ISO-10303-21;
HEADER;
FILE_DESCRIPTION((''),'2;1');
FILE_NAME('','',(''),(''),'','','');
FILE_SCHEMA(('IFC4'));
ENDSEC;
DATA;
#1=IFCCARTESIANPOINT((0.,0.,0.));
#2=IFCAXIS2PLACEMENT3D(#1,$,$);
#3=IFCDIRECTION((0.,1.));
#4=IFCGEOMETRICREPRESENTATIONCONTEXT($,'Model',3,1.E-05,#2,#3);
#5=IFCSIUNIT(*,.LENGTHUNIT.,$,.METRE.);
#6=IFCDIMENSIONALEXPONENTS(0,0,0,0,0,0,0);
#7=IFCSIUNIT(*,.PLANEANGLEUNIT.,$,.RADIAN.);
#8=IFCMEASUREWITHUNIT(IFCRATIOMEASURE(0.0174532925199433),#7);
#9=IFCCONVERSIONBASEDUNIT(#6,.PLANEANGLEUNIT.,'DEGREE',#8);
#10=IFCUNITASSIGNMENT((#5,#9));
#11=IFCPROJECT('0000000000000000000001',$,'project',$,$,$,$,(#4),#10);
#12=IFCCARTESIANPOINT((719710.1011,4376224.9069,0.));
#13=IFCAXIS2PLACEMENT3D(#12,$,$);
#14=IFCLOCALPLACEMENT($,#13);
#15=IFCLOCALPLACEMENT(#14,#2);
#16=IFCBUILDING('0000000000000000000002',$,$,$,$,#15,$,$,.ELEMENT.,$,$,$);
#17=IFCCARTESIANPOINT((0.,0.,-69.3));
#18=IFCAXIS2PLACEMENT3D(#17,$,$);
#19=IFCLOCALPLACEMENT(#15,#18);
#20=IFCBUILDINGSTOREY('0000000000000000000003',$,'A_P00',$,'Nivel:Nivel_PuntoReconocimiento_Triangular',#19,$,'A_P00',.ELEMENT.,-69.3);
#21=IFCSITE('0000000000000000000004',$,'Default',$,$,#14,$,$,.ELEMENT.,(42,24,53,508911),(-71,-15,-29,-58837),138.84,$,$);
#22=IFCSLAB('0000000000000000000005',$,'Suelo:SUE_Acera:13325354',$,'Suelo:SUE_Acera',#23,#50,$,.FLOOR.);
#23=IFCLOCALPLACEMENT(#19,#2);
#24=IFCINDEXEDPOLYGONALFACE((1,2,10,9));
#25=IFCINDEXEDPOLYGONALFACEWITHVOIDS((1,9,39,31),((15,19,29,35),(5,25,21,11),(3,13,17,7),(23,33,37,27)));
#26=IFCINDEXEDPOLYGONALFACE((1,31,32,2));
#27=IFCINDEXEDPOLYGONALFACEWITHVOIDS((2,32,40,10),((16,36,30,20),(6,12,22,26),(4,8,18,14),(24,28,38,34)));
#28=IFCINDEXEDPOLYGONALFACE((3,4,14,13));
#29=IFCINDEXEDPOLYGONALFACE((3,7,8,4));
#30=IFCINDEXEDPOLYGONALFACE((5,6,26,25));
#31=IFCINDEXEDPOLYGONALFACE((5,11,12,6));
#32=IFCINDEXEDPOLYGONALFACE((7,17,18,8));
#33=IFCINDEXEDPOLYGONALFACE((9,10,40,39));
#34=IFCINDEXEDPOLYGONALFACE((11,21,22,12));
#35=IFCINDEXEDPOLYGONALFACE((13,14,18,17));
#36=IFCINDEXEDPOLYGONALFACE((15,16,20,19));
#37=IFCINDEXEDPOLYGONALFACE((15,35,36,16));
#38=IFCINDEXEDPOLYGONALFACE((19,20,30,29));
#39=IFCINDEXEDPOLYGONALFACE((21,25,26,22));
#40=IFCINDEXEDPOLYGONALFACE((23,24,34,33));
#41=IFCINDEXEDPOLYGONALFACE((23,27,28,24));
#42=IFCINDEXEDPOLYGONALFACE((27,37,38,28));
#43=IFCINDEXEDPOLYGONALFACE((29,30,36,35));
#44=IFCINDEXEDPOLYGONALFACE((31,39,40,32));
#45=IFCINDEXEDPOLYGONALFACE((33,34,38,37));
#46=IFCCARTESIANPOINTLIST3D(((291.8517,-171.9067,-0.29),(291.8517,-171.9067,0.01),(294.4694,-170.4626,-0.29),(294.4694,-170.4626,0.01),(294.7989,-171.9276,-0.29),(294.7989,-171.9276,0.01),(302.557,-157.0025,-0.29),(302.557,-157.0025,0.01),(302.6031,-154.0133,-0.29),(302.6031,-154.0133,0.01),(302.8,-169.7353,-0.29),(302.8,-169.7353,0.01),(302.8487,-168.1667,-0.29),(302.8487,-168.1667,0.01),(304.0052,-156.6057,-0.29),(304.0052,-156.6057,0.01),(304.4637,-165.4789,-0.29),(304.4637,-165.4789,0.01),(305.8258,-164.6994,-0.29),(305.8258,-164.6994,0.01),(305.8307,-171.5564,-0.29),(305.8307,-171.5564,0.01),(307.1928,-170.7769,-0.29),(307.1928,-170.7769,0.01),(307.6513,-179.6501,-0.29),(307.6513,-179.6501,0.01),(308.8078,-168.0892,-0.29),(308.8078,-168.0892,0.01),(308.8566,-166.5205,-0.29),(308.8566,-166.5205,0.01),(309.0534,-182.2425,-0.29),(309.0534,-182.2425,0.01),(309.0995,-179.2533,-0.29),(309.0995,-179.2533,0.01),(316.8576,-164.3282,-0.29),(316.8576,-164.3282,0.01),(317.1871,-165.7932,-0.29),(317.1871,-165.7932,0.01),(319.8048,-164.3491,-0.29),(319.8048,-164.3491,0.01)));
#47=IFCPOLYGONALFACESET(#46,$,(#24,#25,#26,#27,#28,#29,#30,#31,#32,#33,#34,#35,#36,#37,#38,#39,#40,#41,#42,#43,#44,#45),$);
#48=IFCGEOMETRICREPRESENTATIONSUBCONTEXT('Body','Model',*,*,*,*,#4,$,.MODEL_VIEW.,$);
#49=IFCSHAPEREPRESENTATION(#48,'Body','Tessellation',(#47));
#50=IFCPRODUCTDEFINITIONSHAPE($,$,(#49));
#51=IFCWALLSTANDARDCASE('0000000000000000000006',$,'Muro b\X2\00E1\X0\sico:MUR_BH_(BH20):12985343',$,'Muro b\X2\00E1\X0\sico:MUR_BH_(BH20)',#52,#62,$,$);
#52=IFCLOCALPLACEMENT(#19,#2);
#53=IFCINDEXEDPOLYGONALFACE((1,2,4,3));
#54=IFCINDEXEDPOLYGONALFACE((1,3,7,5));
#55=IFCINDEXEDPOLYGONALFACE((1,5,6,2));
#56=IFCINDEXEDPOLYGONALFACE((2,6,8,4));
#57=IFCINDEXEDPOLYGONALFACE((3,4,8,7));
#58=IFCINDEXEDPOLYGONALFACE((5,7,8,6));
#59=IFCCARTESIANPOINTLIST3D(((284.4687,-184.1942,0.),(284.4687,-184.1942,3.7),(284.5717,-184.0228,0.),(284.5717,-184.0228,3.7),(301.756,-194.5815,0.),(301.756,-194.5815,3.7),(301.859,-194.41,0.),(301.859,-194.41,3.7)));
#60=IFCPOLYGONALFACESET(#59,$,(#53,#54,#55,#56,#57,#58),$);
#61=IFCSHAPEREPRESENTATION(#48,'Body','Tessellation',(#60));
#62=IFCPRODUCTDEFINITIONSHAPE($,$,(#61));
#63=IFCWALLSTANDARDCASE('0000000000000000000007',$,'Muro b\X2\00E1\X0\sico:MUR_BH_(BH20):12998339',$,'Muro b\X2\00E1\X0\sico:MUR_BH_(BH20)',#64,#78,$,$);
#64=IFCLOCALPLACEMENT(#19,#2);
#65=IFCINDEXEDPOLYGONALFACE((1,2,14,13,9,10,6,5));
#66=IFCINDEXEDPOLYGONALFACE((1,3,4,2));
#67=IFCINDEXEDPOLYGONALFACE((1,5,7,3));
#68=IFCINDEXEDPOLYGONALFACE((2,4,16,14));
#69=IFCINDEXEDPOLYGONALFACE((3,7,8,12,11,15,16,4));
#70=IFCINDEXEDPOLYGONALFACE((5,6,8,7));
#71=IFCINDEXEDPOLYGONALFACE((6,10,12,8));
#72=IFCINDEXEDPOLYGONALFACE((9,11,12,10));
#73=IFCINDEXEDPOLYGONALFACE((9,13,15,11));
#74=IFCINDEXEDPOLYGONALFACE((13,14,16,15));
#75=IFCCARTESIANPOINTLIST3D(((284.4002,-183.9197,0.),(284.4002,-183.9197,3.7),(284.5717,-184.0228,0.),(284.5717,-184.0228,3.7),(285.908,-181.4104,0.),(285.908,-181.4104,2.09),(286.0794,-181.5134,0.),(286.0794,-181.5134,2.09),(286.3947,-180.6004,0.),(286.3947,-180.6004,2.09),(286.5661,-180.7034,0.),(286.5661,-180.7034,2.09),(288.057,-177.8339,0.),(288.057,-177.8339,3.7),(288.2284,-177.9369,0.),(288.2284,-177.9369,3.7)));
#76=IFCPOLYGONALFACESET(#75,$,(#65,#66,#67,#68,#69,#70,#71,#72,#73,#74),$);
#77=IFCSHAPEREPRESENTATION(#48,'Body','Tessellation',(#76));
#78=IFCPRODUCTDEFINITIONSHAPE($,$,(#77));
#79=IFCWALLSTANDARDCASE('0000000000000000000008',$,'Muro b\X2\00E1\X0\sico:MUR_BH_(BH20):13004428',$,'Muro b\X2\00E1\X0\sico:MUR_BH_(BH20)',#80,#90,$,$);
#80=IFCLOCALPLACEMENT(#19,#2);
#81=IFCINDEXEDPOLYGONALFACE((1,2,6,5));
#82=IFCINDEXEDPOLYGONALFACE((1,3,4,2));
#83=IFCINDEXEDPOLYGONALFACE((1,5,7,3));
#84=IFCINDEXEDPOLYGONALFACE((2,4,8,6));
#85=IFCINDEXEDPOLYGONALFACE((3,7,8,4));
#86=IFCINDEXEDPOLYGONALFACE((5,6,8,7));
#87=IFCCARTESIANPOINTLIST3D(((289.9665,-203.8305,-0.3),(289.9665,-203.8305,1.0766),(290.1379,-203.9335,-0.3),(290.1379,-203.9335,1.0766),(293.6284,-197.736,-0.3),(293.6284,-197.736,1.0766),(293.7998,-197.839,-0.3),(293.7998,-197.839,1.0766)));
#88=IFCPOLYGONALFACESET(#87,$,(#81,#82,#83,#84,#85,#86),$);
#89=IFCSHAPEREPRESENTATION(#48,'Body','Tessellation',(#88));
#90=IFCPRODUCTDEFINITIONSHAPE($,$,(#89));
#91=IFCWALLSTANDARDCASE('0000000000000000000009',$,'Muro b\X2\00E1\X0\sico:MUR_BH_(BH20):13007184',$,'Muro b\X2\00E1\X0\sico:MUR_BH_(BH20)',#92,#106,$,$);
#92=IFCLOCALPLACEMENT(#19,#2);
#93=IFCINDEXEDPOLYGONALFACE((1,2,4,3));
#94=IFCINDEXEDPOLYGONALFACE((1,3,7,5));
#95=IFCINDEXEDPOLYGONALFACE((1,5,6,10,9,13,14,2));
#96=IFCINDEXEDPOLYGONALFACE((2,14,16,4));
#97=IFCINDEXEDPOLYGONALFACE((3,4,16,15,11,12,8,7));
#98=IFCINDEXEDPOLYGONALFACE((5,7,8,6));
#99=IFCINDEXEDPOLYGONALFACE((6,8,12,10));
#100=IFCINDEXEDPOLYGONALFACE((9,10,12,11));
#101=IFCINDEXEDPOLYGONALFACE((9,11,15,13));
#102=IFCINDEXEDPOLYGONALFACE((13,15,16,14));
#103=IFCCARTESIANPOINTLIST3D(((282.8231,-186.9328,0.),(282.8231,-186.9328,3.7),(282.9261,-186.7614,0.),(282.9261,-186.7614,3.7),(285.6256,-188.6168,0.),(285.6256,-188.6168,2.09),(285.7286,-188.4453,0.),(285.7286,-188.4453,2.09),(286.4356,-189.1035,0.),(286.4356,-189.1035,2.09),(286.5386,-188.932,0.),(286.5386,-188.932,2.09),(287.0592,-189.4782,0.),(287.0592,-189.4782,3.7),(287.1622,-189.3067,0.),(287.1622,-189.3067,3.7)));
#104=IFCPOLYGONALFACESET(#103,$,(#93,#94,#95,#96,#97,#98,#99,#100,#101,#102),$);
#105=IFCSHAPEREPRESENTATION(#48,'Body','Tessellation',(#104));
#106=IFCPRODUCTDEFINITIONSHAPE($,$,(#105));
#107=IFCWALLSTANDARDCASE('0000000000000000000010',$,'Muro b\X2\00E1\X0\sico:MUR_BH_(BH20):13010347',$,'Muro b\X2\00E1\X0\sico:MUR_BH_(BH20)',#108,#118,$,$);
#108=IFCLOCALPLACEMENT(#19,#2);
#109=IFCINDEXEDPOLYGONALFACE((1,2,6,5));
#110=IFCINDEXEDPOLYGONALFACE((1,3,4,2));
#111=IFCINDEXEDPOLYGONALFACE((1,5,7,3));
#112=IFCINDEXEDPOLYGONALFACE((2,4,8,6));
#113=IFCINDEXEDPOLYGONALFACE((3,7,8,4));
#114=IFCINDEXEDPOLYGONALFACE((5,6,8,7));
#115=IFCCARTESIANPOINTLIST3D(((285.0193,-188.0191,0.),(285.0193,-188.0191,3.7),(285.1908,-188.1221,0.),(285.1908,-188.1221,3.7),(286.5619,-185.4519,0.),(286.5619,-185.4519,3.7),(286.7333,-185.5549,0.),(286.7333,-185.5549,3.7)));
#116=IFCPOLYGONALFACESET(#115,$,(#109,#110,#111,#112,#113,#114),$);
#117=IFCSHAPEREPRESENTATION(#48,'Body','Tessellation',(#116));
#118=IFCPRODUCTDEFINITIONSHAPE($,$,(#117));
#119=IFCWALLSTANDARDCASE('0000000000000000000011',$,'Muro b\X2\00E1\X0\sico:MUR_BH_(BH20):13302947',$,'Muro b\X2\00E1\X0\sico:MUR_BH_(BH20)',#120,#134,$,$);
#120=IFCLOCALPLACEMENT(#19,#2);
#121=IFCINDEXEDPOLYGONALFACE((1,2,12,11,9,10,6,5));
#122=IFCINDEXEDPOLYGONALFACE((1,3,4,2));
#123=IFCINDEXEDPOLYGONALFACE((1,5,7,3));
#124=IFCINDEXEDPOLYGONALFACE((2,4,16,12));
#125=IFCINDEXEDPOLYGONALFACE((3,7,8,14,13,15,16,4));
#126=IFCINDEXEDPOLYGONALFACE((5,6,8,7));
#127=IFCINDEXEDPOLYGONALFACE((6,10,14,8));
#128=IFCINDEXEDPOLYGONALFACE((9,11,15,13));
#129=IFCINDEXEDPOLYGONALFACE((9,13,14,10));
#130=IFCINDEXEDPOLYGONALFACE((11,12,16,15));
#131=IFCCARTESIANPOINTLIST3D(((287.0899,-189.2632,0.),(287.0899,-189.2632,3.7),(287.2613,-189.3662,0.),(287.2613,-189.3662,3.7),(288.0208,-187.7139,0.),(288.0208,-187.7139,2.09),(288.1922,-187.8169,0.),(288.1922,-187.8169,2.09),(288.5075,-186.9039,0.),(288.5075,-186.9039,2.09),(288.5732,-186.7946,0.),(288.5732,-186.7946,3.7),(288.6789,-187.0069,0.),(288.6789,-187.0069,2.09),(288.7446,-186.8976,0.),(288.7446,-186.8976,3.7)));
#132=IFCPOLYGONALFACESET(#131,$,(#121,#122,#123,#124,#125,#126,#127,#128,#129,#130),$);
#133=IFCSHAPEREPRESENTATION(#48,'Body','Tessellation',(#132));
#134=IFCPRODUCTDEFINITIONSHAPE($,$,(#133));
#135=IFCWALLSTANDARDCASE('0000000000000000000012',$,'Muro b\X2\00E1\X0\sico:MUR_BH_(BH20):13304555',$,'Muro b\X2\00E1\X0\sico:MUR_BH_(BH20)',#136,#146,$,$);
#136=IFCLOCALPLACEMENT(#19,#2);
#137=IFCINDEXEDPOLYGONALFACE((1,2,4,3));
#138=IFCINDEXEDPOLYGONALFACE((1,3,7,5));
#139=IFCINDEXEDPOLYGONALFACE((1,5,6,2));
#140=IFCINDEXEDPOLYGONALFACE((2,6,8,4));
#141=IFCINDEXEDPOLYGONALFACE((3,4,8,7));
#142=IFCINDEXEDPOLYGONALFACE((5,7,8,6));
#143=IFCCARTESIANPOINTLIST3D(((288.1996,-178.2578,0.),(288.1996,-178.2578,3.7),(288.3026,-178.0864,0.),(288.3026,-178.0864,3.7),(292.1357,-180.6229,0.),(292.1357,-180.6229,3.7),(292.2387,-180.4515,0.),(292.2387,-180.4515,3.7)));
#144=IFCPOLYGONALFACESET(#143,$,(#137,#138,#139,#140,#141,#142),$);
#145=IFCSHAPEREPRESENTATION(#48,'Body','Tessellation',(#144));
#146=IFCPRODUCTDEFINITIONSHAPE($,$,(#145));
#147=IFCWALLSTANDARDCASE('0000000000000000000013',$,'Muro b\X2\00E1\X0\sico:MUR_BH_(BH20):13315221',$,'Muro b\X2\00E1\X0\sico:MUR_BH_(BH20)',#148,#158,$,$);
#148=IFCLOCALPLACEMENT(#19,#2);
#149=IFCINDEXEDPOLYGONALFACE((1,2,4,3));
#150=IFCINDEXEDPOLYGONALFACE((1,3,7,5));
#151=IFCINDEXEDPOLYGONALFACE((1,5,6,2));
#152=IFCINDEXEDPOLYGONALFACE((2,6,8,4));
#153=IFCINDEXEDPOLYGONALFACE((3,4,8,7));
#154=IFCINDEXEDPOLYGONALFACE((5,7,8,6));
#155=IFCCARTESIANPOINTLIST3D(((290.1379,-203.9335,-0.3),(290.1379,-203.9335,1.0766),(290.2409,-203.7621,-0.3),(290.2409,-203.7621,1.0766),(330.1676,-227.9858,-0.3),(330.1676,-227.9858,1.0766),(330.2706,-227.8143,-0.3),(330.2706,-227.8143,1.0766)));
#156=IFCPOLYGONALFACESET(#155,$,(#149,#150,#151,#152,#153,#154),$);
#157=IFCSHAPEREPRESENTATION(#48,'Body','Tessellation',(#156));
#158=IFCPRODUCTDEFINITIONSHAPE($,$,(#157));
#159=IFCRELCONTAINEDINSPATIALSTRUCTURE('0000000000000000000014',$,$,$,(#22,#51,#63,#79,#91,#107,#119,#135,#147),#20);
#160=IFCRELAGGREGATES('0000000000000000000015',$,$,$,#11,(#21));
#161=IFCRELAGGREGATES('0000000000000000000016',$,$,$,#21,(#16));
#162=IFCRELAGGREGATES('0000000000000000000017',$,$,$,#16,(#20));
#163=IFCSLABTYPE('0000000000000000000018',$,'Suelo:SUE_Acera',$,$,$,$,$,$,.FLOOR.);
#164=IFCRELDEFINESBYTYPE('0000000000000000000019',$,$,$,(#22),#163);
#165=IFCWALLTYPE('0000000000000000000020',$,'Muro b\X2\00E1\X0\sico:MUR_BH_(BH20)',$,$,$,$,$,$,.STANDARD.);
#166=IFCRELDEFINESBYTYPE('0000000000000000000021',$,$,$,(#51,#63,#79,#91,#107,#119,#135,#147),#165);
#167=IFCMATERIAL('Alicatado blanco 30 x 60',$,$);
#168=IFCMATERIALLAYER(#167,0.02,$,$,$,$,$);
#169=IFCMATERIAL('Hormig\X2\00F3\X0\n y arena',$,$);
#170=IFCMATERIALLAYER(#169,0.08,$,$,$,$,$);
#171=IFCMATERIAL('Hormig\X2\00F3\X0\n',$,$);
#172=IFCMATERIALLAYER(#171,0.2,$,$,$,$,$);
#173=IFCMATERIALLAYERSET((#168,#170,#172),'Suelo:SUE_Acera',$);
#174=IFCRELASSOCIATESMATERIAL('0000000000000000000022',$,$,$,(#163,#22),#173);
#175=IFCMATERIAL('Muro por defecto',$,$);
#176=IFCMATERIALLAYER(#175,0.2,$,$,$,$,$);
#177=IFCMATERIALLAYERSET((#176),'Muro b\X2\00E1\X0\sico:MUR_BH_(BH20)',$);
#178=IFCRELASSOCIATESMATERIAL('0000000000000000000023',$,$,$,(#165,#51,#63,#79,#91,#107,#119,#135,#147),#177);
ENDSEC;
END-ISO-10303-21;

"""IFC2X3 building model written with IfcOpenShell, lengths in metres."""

from ifc_helpers import new_model, entity, si_unit, converted_unit, direction, frame, frame_2d, origin, place, context, subcontext, project, spatial, polyline, rectangle, outline, extrude, material, layer, layer_set, layer_usage, type_object, element, save


model = new_model("IFC2X3")

# Units and contexts
model_context = context("Model", 3, precision=1e-05, world=origin(), true_north=direction((0.0, 1.0)))
body_context = subcontext(model_context, "Body", "Model", "MODEL_VIEW")
ifc_project = project(units=[si_unit("LENGTHUNIT", "METRE"), converted_unit("PLANEANGLEUNIT", "DEGREE", entity("IfcRatioMeasure", 0.0174532925199433), si_unit("PLANEANGLEUNIT", "RADIAN"), dimensions=[0, 0, 0, 0, 0, 0, 0])], contexts=[model_context])

# Site, building, storey
site_placement = place(None, frame((719710.1011, 4376224.9069, 0.0)))
site = spatial("IfcSite", under=ifc_project, at=site_placement, Name="Default", CompositionType="ELEMENT", RefLatitude=(42, 24, 53, 508911), RefLongitude=(-71, -15, -29, -58837), RefElevation=138.84)
building_placement = place(site_placement, origin())
building = spatial("IfcBuilding", under=site, at=building_placement, CompositionType="ELEMENT")
storey_placement = place(building_placement, frame((0.0, 0.0, -69.3)))
storey = spatial("IfcBuildingStorey", under=building, at=storey_placement, Name="A_P00", ObjectType="Nivel:Nivel_PuntoReconocimiento_Triangular", LongName="A_P00", CompositionType="ELEMENT", Elevation=-69.3)

# Slab, openings
ifc_material_1 = material(Name="Alicatado blanco 30 x 60")
ifc_layer_1 = layer(ifc_material_1, 0.02)
ifc_material_2 = material(Name="Hormigón y arena")
ifc_layer_2 = layer(ifc_material_2, 0.08)
ifc_material_3 = material(Name="Hormigón")
ifc_layer_3 = layer(ifc_material_3, 0.2)
ifc_layer_set_1 = layer_set([ifc_layer_1, ifc_layer_2, ifc_layer_3], Name="Suelo:SUE_Acera")
ifc_layer_usage_1 = layer_usage(ifc_layer_set_1, "AXIS3", "POSITIVE", 0.0)
slab_type = type_object("IfcSlabType", Name="Suelo:SUE_Acera", PredefinedType="FLOOR", material=ifc_layer_set_1)
slab_placement = place(storey_placement, frame((291.8517, -182.2425, -0.29)))
slab = element("IfcSlab", 1, at=slab_placement, inside=storey, type_object=slab_type, material=ifc_layer_usage_1, Name="Suelo:SUE_Acera:13325354", ObjectType="Suelo:SUE_Acera", PredefinedType="FLOOR", context=body_context, shape_type="SweptSolid", body=[
    extrude(rectangle(XDim=20.068, YDim=20.875, at=frame_2d((0.0, 0.0), x_axis=(-0.857167, -0.515038))), frame((13.9765, 14.1146, 0.3), z_axis=(0.0, 0.0, -1.0), x_axis=(-1.0, 0.0, 0.0)), (0.0, 0.0, 1.0), 0.3),
])
opening_1_placement = place(slab_placement, frame((10.9185, 9.0251, 0.3)))
element("IfcOpeningElement", 2, at=opening_1_placement, cuts=slab, ObjectType="Opening", context=body_context, shape_type="SweptSolid", body=[
    extrude(outline(polyline([(-7.497, 3.0), (-1.7679, -3.0), (1.7679, -3.0), (7.497, 3.0), (-7.497, 3.0)])), frame((0.0, 0.0, 0.0), z_axis=(0.0, 0.0, 1.0), x_axis=(-0.857167, 0.515038, 0.0)), (0.0, 0.0, -1.0), 0.3),
])
opening_2_placement = place(slab_placement, frame((9.233, 16.9648, 0.3)))
element("IfcOpeningElement", 3, at=opening_2_placement, cuts=slab, ObjectType="Opening", context=body_context, shape_type="SweptSolid", body=[
    extrude(outline(polyline([(-7.8515, 3.0), (-1.5678, -3.0), (1.5678, -3.0), (7.8515, 3.0), (-7.8515, 3.0)])), frame((0.0, 0.0, 0.0), z_axis=(0.0, 0.0, 1.0), x_axis=(0.515038, 0.857167, 0.0)), (0.0, 0.0, -1.0), 0.3),
])
opening_3_placement = place(slab_placement, frame((17.0346, 19.204, 0.3)))
element("IfcOpeningElement", 4, at=opening_3_placement, cuts=slab, ObjectType="Opening", context=body_context, shape_type="SweptSolid", body=[
    extrude(outline(polyline([(-7.497, -3.0), (7.497, -3.0), (1.7679, 3.0), (-1.7679, 3.0), (-7.497, -3.0)])), frame((0.0, 0.0, 0.0), z_axis=(0.0, 0.0, -1.0), x_axis=(0.857167, -0.515038, 0.0)), (0.0, 0.0, 1.0), 0.3),
])
opening_4_placement = place(slab_placement, frame((18.7201, 11.2644, 0.3)))
element("IfcOpeningElement", 5, at=opening_4_placement, cuts=slab, ObjectType="Opening", context=body_context, shape_type="SweptSolid", body=[
    extrude(outline(polyline([(-7.8515, -3.0), (7.8515, -3.0), (1.5678, 3.0), (-1.5678, 3.0), (-7.8515, -3.0)])), frame((0.0, 0.0, 0.0), z_axis=(0.0, 0.0, -1.0), x_axis=(-0.515038, -0.857167, 0.0)), (0.0, 0.0, 1.0), 0.3),
])

# Wall
ifc_material_4 = material(Name="Muro por defecto")
ifc_layer_4 = layer(ifc_material_4, 0.2)
ifc_layer_set_2 = layer_set([ifc_layer_4], Name="Muro básico:MUR_BH_(BH20)")
ifc_layer_usage_2 = layer_usage(ifc_layer_set_2, "AXIS2", "NEGATIVE", 0.1)
wall_type = type_object("IfcWallType", Name="Muro básico:MUR_BH_(BH20)", PredefinedType="STANDARD", material=ifc_layer_set_2)
wall_1_placement = place(storey_placement, frame((284.5202, -184.1085, 0.0), z_axis=(0.0, 0.0, 1.0), x_axis=(0.857167, -0.515038, 0.0)))
element("IfcWallStandardCase", 6, at=wall_1_placement, inside=storey, type_object=wall_type, material=ifc_layer_usage_2, Name="Muro básico:MUR_BH_(BH20):12985343", ObjectType="Muro básico:MUR_BH_(BH20)", context=body_context, shape_type="SweptSolid", body=[
    extrude(rectangle(XDim=20.168, YDim=0.2, at=frame_2d((10.084, 0.0), x_axis=(-1.0, 0.0))), origin(), (0.0, 0.0, 1.0), 3.7),
])

# Wall, opening
ifc_layer_usage_3 = layer_usage(ifc_layer_set_2, "AXIS2", "NEGATIVE", 0.1)
wall_2_placement = place(storey_placement, frame((288.1427, -177.8854, 0.0), z_axis=(0.0, 0.0, 1.0), x_axis=(-0.515038, -0.857167, 0.0)))
wall_2 = element("IfcWallStandardCase", 7, at=wall_2_placement, inside=storey, type_object=wall_type, material=ifc_layer_usage_3, Name="Muro básico:MUR_BH_(BH20):12998339", ObjectType="Muro básico:MUR_BH_(BH20)", context=body_context, shape_type="SweptSolid", body=[
    extrude(rectangle(XDim=7.1, YDim=0.2, at=frame_2d((3.55, 0.0), x_axis=(-1.0, 0.0))), origin(), (0.0, 0.0, 1.0), 3.7),
])
opening_5_placement = place(wall_2_placement, frame((-4.073, -338.6042, 0.0), z_axis=(0.0, 0.0, 1.0), x_axis=(-0.515038, 0.857167, 0.0)))
element("IfcOpeningElement", 8, at=opening_5_placement, cuts=wall_2, ObjectType="Opening", context=body_context, shape_type="SweptSolid", body=[
    extrude(rectangle(XDim=2.09, YDim=0.945, at=frame_2d((0.0, 0.0), x_axis=(0.0, 1.0))), frame((286.1514, -181.0054, 1.045), z_axis=(0.857167, -0.515038, 0.0), x_axis=(-0.515038, -0.857167, 0.0)), (0.0, 0.0, 1.0), 0.2),
])

# Wall
ifc_layer_usage_4 = layer_usage(ifc_layer_set_2, "AXIS2", "NEGATIVE", 0.1)
wall_3_placement = place(storey_placement, frame((290.0522, -203.882, -0.3), z_axis=(0.0, 0.0, 1.0), x_axis=(0.515038, 0.857167, 0.0)))
element("IfcWallStandardCase", 9, at=wall_3_placement, inside=storey, type_object=wall_type, material=ifc_layer_usage_4, Name="Muro básico:MUR_BH_(BH20):13004428", ObjectType="Muro básico:MUR_BH_(BH20)", context=body_context, shape_type="SweptSolid", body=[
    extrude(rectangle(XDim=7.11, YDim=0.2, at=frame_2d((3.555, 0.0), x_axis=(-1.0, 0.0))), origin(), (0.0, 0.0, 1.0), 1.3766),
])

# Wall, opening
ifc_layer_usage_5 = layer_usage(ifc_layer_set_2, "AXIS2", "NEGATIVE", 0.1)
wall_4_placement = place(storey_placement, frame((287.1107, -189.3924, 0.0), z_axis=(0.0, 0.0, 1.0), x_axis=(-0.857167, 0.515038, 0.0)))
wall_4 = element("IfcWallStandardCase", 10, at=wall_4_placement, inside=storey, type_object=wall_type, material=ifc_layer_usage_5, Name="Muro básico:MUR_BH_(BH20):13007184", ObjectType="Muro básico:MUR_BH_(BH20)", context=body_context, shape_type="SweptSolid", body=[
    extrude(rectangle(XDim=4.942, YDim=0.2, at=frame_2d((2.471, 0.0), x_axis=(-1.0, 0.0))), origin(), (0.0, 0.0, 1.0), 3.7),
])
opening_6_placement = place(wall_4_placement, frame((343.6462, -14.468, 0.0), z_axis=(0.0, 0.0, 1.0), x_axis=(-0.857167, -0.515038, 0.0)))
element("IfcOpeningElement", 11, at=opening_6_placement, cuts=wall_4, ObjectType="Opening", context=body_context, shape_type="SweptSolid", body=[
    extrude(rectangle(XDim=2.09, YDim=0.945, at=frame_2d((0.0, 0.0), x_axis=(0.0, 1.0))), frame((286.1336, -188.6887, 1.045), z_axis=(-0.515038, -0.857167, 0.0), x_axis=(-0.857167, 0.515038, 0.0)), (0.0, 0.0, 1.0), 0.2),
])

# Wall
ifc_layer_usage_6 = layer_usage(ifc_layer_set_2, "AXIS2", "NEGATIVE", 0.1)
wall_5_placement = place(storey_placement, frame((285.105, -188.0706, 0.0), z_axis=(0.0, 0.0, 1.0), x_axis=(0.515038, 0.857167, 0.0)))
element("IfcWallStandardCase", 12, at=wall_5_placement, inside=storey, type_object=wall_type, material=ifc_layer_usage_6, Name="Muro básico:MUR_BH_(BH20):13010347", ObjectType="Muro básico:MUR_BH_(BH20)", context=body_context, shape_type="SweptSolid", body=[
    extrude(rectangle(XDim=2.995, YDim=0.2, at=frame_2d((1.4975, 0.0), x_axis=(-1.0, 0.0))), origin(), (0.0, 0.0, 1.0), 3.7),
])

# Wall, opening
ifc_layer_usage_7 = layer_usage(ifc_layer_set_2, "AXIS2", "NEGATIVE", 0.1)
wall_6_placement = place(storey_placement, frame((288.6589, -186.8461, 0.0), z_axis=(0.0, 0.0, 1.0), x_axis=(-0.515038, -0.857167, 0.0)))
wall_6 = element("IfcWallStandardCase", 13, at=wall_6_placement, inside=storey, type_object=wall_type, material=ifc_layer_usage_7, Name="Muro básico:MUR_BH_(BH20):13302947", ObjectType="Muro básico:MUR_BH_(BH20)", context=body_context, shape_type="SweptSolid", body=[
    extrude(rectangle(XDim=2.88, YDim=0.2, at=frame_2d((1.44, 0.0), x_axis=(-1.0, 0.0))), origin(), (0.0, 0.0, 1.0), 3.7),
])
opening_7_placement = place(wall_6_placement, frame((-11.488, -343.6618, 0.0), z_axis=(0.0, 0.0, 1.0), x_axis=(-0.515038, 0.857167, 0.0)))
element("IfcOpeningElement", 14, at=opening_7_placement, cuts=wall_6, ObjectType="Opening", context=body_context, shape_type="SweptSolid", body=[
    extrude(rectangle(XDim=2.09, YDim=0.945, at=frame_2d((0.0, 0.0), x_axis=(0.0, 1.0))), frame((288.2641, -187.3089, 1.045), z_axis=(0.857167, -0.515038, 0.0), x_axis=(-0.515038, -0.857167, 0.0)), (0.0, 0.0, 1.0), 0.2),
])

# Walls
ifc_layer_usage_8 = layer_usage(ifc_layer_set_2, "AXIS2", "NEGATIVE", 0.1)
wall_7_placement = place(storey_placement, frame((292.1872, -180.5372, 0.0), z_axis=(0.0, 0.0, 1.0), x_axis=(-0.857167, 0.515038, 0.0)))
element("IfcWallStandardCase", 15, at=wall_7_placement, inside=storey, type_object=wall_type, material=ifc_layer_usage_8, Name="Muro básico:MUR_BH_(BH20):13304555", ObjectType="Muro básico:MUR_BH_(BH20)", context=body_context, shape_type="SweptSolid", body=[
    extrude(rectangle(XDim=4.592, YDim=0.2, at=frame_2d((2.296, 0.0), x_axis=(-1.0, 0.0))), origin(), (0.0, 0.0, 1.0), 3.7),
])
ifc_layer_usage_9 = layer_usage(ifc_layer_set_2, "AXIS2", "NEGATIVE", 0.1)
wall_8_placement = place(storey_placement, frame((290.1894, -203.8478, -0.3), z_axis=(0.0, 0.0, 1.0), x_axis=(0.857167, -0.515038, 0.0)))
element("IfcWallStandardCase", 16, at=wall_8_placement, inside=storey, type_object=wall_type, material=ifc_layer_usage_9, Name="Muro básico:MUR_BH_(BH20):13315221", ObjectType="Muro básico:MUR_BH_(BH20)", context=body_context, shape_type="SweptSolid", body=[
    extrude(rectangle(XDim=46.7, YDim=0.2, at=frame_2d((23.35, 0.0), x_axis=(-1.0, 0.0))), origin(), (0.0, 0.0, 1.0), 1.3766),
])

save(model, "model.ifc")
